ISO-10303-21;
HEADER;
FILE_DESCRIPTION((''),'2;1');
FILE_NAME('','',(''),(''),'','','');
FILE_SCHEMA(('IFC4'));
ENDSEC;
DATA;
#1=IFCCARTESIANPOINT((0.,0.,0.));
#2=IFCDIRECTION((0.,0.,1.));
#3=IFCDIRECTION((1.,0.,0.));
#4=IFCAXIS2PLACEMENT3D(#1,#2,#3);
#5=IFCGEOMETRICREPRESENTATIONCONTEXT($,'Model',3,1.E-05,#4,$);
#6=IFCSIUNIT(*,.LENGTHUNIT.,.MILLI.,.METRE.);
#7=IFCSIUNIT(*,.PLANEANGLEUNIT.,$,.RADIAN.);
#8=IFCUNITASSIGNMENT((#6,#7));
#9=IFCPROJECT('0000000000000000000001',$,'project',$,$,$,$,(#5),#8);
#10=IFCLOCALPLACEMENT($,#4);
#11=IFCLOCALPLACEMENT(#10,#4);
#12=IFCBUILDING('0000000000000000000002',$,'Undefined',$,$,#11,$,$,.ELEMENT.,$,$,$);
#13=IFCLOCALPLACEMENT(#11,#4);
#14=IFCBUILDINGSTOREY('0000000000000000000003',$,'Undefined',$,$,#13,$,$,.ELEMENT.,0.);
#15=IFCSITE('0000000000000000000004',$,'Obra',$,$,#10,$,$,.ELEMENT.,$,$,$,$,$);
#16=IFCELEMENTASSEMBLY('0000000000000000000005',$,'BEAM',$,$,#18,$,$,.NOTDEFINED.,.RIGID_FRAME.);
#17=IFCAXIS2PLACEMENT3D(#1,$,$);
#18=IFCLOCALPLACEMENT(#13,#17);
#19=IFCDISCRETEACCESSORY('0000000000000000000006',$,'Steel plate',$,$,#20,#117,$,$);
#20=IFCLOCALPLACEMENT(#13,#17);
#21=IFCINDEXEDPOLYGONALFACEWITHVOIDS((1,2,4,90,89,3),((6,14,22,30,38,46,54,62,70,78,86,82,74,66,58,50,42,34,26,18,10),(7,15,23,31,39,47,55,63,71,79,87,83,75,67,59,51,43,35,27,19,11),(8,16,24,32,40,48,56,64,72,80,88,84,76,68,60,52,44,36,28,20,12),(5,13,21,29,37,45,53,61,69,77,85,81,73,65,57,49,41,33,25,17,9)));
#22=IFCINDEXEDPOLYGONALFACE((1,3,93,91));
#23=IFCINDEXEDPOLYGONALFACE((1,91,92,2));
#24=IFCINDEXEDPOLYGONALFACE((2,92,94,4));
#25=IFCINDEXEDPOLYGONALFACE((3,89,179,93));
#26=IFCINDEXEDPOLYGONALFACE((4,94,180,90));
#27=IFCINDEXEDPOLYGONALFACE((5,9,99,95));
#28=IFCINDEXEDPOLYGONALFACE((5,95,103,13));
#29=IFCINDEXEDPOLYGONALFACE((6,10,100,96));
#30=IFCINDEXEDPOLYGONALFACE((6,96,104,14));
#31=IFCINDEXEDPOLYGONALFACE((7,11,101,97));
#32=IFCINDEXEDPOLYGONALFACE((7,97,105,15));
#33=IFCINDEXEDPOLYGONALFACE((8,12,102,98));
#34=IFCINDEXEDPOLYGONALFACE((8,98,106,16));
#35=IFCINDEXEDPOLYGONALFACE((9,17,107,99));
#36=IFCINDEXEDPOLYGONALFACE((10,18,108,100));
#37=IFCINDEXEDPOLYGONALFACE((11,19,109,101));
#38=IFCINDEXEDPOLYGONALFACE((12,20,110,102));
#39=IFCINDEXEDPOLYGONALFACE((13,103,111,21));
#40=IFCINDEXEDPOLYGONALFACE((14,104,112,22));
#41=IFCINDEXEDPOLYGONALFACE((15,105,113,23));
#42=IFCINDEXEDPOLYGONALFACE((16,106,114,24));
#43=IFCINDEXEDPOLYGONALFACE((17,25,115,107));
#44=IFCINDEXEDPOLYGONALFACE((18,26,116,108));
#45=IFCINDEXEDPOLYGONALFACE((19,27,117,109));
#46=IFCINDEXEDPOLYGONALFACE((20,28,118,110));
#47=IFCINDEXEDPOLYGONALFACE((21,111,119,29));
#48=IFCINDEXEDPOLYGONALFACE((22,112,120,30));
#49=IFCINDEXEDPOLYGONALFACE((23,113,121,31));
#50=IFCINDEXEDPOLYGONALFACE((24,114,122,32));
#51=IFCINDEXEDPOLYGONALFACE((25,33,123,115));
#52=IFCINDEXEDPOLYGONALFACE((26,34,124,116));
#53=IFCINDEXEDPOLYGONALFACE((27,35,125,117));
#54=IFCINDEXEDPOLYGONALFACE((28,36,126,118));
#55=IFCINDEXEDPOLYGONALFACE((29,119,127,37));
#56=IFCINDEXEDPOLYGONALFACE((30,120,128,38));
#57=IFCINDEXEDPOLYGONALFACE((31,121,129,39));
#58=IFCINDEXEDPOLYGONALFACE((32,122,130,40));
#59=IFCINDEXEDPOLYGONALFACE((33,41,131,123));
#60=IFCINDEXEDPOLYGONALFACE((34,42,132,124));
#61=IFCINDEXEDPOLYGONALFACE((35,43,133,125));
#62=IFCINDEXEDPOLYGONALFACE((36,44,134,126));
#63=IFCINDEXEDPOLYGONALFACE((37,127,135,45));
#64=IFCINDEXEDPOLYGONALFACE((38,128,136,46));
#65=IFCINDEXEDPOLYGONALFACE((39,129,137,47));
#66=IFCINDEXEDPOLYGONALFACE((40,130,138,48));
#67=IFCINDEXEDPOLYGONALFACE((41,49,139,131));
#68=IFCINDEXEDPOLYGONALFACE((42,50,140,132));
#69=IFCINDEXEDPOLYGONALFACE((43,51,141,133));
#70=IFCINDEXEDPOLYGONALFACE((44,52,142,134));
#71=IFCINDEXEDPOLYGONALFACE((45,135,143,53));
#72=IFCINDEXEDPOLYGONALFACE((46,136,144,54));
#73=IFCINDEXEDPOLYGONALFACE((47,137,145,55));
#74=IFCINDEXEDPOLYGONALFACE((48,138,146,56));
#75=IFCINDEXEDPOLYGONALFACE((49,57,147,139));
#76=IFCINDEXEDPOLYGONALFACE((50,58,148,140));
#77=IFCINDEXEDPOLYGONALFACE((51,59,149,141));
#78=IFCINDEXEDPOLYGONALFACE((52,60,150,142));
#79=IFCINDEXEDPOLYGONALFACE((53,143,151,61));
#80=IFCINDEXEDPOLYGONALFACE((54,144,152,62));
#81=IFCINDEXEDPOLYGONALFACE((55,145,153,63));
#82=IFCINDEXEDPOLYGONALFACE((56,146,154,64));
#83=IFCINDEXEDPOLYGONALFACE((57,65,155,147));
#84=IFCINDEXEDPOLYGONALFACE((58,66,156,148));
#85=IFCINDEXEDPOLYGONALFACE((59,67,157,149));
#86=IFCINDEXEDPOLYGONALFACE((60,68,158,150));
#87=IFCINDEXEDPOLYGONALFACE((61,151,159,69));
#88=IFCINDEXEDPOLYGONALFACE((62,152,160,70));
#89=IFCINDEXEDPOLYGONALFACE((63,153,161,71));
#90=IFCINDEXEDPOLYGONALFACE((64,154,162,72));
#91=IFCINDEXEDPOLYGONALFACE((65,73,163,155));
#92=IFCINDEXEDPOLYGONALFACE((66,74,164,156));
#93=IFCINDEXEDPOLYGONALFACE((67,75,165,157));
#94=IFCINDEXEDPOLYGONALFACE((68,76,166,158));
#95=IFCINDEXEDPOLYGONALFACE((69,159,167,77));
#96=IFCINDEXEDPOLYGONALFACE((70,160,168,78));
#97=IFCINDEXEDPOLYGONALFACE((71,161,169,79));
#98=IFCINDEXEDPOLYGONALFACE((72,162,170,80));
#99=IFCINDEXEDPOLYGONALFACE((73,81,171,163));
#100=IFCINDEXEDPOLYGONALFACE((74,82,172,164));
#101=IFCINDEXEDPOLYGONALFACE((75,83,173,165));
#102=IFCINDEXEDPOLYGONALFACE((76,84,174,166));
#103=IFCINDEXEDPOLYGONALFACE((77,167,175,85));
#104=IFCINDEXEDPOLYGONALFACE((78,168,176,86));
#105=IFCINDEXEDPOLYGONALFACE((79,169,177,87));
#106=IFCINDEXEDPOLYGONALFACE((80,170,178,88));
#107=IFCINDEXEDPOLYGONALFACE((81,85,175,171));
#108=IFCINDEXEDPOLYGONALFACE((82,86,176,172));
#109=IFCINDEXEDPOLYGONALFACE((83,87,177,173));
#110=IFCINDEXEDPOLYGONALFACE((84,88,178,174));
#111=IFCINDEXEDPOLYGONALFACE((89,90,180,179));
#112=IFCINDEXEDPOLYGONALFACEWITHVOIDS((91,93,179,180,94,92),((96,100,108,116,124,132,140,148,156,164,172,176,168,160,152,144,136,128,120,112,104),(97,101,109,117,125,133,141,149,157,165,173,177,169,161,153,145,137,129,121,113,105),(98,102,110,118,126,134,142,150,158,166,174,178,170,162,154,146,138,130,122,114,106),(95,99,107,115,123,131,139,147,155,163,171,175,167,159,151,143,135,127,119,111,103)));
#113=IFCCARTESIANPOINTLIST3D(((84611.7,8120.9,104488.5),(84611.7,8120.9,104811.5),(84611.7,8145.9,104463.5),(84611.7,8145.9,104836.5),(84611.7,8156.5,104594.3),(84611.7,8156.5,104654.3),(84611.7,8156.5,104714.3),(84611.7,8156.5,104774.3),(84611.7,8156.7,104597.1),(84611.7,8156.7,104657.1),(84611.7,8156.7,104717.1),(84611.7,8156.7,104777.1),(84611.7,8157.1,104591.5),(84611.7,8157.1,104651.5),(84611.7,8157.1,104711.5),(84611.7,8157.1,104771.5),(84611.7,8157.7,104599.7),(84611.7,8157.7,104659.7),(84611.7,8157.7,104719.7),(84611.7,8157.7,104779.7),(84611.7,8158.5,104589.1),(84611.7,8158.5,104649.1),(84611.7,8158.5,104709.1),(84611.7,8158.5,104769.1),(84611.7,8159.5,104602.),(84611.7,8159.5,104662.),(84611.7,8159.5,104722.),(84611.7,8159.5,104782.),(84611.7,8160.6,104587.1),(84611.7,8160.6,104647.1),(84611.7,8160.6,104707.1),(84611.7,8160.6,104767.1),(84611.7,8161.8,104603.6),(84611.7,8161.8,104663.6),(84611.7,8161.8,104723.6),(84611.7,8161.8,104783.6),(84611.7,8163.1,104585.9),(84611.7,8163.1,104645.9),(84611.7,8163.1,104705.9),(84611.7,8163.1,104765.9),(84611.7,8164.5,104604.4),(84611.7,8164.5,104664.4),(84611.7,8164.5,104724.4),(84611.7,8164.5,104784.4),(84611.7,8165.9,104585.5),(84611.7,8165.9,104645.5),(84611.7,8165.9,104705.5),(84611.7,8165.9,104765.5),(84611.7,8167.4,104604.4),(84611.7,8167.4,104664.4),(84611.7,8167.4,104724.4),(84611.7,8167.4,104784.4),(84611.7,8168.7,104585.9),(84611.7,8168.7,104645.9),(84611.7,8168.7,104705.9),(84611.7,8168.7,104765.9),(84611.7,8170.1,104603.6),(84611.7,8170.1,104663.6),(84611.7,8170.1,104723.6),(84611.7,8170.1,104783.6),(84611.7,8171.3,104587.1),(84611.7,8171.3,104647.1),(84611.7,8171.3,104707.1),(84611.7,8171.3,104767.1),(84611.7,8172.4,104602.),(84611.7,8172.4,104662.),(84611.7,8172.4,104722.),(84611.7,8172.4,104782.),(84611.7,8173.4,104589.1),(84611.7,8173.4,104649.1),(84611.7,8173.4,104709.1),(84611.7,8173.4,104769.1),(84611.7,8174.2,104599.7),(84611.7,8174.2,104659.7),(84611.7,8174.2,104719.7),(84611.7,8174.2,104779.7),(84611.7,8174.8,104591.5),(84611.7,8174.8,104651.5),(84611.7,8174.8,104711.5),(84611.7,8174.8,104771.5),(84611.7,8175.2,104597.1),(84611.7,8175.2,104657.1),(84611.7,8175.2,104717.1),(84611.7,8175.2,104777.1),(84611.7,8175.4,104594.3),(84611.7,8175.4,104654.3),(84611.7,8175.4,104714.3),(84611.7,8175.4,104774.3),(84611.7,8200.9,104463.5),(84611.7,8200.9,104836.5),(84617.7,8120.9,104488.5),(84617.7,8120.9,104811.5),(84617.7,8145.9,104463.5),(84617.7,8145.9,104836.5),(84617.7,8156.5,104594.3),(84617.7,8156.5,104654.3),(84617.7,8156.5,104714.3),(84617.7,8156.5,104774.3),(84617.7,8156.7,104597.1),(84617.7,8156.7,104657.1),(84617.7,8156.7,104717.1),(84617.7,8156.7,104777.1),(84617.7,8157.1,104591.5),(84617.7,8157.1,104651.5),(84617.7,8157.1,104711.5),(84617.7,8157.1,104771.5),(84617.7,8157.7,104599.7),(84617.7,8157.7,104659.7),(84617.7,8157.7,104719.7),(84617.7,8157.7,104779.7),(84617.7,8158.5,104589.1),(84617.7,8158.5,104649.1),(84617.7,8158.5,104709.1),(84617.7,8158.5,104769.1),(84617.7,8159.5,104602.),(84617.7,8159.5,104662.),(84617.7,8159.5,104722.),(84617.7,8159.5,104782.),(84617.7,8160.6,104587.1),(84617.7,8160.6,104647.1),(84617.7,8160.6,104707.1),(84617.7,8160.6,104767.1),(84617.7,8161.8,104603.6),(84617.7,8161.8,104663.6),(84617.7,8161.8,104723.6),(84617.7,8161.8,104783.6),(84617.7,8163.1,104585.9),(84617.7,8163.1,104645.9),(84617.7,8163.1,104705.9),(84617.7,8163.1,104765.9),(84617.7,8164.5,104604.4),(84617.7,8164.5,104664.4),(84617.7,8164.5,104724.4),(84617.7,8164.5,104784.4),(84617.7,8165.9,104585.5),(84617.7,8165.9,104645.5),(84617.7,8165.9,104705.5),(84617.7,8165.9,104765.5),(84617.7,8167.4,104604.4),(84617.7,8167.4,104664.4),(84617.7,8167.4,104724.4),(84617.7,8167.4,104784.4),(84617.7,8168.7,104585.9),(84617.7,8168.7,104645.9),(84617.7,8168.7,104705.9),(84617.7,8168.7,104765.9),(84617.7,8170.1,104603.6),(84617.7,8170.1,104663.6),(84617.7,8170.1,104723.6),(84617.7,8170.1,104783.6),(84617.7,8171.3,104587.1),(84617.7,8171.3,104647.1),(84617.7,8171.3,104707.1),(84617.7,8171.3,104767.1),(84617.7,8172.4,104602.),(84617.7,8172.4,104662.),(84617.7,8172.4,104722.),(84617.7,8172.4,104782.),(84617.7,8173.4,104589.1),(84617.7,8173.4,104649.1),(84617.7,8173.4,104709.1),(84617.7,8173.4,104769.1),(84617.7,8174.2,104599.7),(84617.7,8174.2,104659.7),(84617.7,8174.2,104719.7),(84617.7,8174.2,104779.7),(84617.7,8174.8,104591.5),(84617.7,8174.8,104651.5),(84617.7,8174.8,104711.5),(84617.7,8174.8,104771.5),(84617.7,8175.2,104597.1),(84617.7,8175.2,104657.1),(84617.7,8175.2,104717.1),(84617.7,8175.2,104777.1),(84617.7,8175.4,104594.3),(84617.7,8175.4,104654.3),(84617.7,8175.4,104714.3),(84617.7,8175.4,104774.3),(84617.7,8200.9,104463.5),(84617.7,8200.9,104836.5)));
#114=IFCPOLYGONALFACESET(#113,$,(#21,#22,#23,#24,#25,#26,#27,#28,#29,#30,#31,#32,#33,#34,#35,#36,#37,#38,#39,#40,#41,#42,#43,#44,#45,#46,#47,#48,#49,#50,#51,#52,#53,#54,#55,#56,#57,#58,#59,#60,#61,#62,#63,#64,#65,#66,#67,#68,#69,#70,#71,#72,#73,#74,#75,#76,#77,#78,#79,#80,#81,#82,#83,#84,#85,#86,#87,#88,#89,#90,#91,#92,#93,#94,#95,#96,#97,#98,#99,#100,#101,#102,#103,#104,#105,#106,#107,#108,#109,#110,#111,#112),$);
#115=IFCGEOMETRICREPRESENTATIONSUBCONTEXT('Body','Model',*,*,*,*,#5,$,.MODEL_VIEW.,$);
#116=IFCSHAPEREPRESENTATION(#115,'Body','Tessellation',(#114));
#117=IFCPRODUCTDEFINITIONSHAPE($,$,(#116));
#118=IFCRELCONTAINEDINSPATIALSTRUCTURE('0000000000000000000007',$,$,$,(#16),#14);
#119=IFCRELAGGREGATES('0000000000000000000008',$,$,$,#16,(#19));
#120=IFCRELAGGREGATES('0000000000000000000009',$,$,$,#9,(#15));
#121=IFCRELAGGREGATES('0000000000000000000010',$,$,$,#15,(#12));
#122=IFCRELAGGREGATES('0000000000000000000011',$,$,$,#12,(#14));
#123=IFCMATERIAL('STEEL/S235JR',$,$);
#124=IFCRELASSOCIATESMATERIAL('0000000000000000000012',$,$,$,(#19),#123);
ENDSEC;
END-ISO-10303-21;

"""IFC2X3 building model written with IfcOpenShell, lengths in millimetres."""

from ifc_helpers import new_model, si_unit, frame, origin_with_axes, origin_2d_with_axis, place, context, subcontext, project, spatial, polyline, circle, outline, extrude, source, transform, mapped, material, element, aggregate, save


model = new_model("IFC2X3")

# Units and contexts
model_context = context("Model", 3, precision=1e-05, world=origin_with_axes())
body_context = subcontext(model_context, "Body", "Model", "MODEL_VIEW")
ifc_project = project(units=[si_unit("LENGTHUNIT", "METRE", prefix="MILLI"), si_unit("PLANEANGLEUNIT", "RADIAN")], contexts=[model_context])

# Site, building, storey
site_placement = place(None, origin_with_axes())
site = spatial("IfcSite", under=ifc_project, at=site_placement, Name="Obra", CompositionType="ELEMENT")
building_placement = place(site_placement, origin_with_axes())
building = spatial("IfcBuilding", under=site, at=building_placement, Name="Undefined", CompositionType="ELEMENT")
storey_placement = place(building_placement, origin_with_axes())
storey = spatial("IfcBuildingStorey", under=building, at=storey_placement, Name="Undefined", CompositionType="ELEMENT", Elevation=0.0)

# Shared definitions
ifc_material = material(Name="STEEL/S235JR")

# Element assembly
assembly_1_placement = place(storey_placement, origin_with_axes())
assembly_1 = element("IfcElementAssembly", 1, at=assembly_1_placement, inside=storey, Name="BEAM", AssemblyPlace="NOTDEFINED", PredefinedType="RIGID_FRAME")

# Discrete accessory, opening
shared_shape_1 = source(origin_with_axes(), body_context, "Body", "SweptSolid", [
    extrude(circle(Radius=9.5, at=origin_2d_with_axis()), frame((0.0, -9.9, 0.0), z_axis=(0.0, 1.0, 0.0), x_axis=(1.0, 0.0, 0.0)), (0.0, 0.0, 1.0), 6.2),
])
discrete_accessory_1_placement = place(assembly_1_placement, frame((84614.7, 8200.9, 104463.5), z_axis=(-1.0, 0.0, 0.0), x_axis=(0.0, -1.0, 0.0)))
discrete_accessory_1 = element("IfcDiscreteAccessory", 2, at=discrete_accessory_1_placement, material=ifc_material, Name="Steel plate", context=body_context, shape_type="SweptSolid", body=[
    extrude(outline(polyline([(0.0, 0.0), (55.0, 0.0), (80.0, 25.0), (80.0, 348.0), (55.0, 373.0), (0.0, 373.0), (0.0, 0.0)])), frame((0.0, 0.0, -3.0), z_axis=(0.0, 0.0, 1.0), x_axis=(1.0, 0.0, 0.0)), (0.0, 0.0, 1.0), 6.0),
])
opening_1_placement = place(assembly_1_placement, frame((84607.9, 8130.9, 104850.0), z_axis=(0.0, 1.0, 0.0), x_axis=(0.0, 0.0, -1.0)))
element("IfcOpeningElement", 3, at=opening_1_placement, cuts=discrete_accessory_1, ObjectType="Opening", context=body_context, shape_type="MappedRepresentation", body=[
    mapped(shared_shape_1, transform((75.0, 0.0, 35.0))),
    mapped(shared_shape_1, transform((135.0, 0.0, 35.0))),
    mapped(shared_shape_1, transform((195.0, 0.0, 35.0))),
    mapped(shared_shape_1, transform((255.0, 0.0, 35.0))),
])
aggregate(assembly_1, [discrete_accessory_1])

save(model, "model.ifc")
